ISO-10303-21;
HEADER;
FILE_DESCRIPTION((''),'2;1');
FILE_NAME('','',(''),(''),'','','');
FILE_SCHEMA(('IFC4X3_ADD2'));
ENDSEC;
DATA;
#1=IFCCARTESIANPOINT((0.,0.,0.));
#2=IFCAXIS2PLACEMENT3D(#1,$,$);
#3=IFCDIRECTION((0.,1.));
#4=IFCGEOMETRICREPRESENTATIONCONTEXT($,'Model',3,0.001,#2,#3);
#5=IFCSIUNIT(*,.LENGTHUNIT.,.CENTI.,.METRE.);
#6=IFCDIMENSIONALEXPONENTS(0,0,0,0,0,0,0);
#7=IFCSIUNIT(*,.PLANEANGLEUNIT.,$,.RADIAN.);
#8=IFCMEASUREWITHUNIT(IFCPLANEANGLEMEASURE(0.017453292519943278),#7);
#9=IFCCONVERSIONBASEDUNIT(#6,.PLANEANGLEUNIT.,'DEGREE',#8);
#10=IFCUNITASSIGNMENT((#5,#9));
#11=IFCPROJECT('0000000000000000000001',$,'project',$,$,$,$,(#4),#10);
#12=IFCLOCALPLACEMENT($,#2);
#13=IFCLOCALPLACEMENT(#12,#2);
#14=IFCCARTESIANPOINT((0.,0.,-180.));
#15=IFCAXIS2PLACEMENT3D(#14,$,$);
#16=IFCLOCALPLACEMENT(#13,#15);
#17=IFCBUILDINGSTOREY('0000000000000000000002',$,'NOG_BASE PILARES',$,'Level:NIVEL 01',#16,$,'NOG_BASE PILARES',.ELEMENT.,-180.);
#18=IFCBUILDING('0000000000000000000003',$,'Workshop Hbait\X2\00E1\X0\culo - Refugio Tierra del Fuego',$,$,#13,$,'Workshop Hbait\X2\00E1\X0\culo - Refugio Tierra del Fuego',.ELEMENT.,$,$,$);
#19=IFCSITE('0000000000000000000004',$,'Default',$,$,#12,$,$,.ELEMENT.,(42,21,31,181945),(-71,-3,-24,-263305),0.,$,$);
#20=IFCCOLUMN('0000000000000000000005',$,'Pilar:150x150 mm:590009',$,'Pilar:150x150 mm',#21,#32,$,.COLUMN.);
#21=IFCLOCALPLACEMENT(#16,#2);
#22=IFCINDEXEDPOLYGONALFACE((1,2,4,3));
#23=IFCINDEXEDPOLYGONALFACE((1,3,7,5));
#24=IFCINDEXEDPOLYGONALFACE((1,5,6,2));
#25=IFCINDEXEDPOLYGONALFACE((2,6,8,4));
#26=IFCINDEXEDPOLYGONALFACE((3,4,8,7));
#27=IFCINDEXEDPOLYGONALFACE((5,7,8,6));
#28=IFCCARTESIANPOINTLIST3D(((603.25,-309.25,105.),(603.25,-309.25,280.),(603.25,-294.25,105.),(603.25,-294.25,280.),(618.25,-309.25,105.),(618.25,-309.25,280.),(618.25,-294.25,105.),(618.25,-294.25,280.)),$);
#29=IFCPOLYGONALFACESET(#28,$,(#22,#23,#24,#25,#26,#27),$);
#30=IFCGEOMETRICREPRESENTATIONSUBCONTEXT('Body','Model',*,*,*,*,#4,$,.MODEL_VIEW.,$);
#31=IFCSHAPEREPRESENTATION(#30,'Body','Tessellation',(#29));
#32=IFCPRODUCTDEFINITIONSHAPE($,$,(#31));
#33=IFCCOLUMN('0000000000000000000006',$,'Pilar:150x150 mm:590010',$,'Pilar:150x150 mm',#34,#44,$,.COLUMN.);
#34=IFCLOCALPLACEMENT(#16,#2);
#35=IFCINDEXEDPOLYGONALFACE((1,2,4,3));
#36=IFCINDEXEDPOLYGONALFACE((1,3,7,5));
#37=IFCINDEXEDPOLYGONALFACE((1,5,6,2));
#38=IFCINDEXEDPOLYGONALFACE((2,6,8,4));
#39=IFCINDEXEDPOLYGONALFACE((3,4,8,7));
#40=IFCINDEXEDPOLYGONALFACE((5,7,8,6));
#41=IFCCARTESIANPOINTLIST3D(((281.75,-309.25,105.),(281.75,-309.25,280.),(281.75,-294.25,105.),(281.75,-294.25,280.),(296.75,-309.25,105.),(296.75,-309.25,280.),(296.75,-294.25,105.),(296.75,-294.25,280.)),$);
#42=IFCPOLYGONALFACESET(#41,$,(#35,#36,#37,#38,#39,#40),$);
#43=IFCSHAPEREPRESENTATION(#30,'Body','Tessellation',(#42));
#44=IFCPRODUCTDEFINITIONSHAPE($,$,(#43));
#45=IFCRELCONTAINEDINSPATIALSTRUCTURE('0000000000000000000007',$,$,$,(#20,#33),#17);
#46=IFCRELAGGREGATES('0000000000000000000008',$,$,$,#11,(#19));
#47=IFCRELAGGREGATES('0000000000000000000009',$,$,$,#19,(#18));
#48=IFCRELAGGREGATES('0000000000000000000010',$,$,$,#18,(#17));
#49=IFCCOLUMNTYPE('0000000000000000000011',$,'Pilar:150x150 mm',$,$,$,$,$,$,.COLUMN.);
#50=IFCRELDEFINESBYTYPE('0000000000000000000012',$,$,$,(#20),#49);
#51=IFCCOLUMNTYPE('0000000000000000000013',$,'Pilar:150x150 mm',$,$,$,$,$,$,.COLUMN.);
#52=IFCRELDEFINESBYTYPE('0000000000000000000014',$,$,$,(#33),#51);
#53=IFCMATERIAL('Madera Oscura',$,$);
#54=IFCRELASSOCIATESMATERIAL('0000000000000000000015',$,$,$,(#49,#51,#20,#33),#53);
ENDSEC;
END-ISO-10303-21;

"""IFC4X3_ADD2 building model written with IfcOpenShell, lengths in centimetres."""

from ifc_helpers import new_model, entity, si_unit, converted_unit, direction, frame, origin, origin_2d_with_axis, place, context, subcontext, project, spatial, rectangle, extrude, source, transform, mapped, material, material_profile, profile_set, profile_usage, type_object, type_shapes, element, save


model = new_model("IFC4X3_ADD2")

# Units and contexts
model_context = context("Model", 3, precision=0.001, world=origin(), true_north=direction((0.0, 1.0)))
body_context = subcontext(model_context, "Body", "Model", "MODEL_VIEW")
ifc_project = project(units=[si_unit("LENGTHUNIT", "METRE", prefix="CENTI"), converted_unit("PLANEANGLEUNIT", "DEGREE", entity("IfcPlaneAngleMeasure", 0.017453292519943278), si_unit("PLANEANGLEUNIT", "RADIAN"), dimensions=[0, 0, 0, 0, 0, 0, 0])], contexts=[model_context])

# Site, building, storey
site_placement = place(None, origin())
site = spatial("IfcSite", under=ifc_project, at=site_placement, Name="Default", CompositionType="ELEMENT", RefLatitude=(42, 21, 31, 181945), RefLongitude=(-71, -3, -24, -263305), RefElevation=0.0)
building_placement = place(site_placement, origin())
building = spatial("IfcBuilding", under=site, at=building_placement, Name="Workshop Hbaitáculo - Refugio Tierra del Fuego", LongName="Workshop Hbaitáculo - Refugio Tierra del Fuego", CompositionType="ELEMENT")
storey_placement = place(building_placement, frame((0.0, 0.0, -180.0)))
storey = spatial("IfcBuildingStorey", under=building, at=storey_placement, Name="NOG_BASE PILARES", ObjectType="Level:NIVEL 01", LongName="NOG_BASE PILARES", CompositionType="ELEMENT", Elevation=-180.0)

# Columns
ifc_material = material(Name="Madera Oscura")
ifc_material_profile = material_profile(ifc_material, rectangle(XDim=15.0, YDim=15.0, at=origin_2d_with_axis()), Name="150x150 mm")
ifc_profile_set = profile_set([ifc_material_profile], Name="150x150 mm")
ifc_profile_usage = profile_usage(ifc_profile_set)
column_type_1 = type_object("IfcColumnType", Name="Pilar:150x150 mm", PredefinedType="COLUMN", material=ifc_profile_set)
shared_shape_1 = source(origin(), body_context, "Body", "SweptSolid", [
    extrude(rectangle(XDim=15.0, YDim=15.0, at=origin_2d_with_axis()), frame((0.0, 0.0, -75.0), z_axis=(0.0, 0.0, 1.0), x_axis=(-1.0, 0.0, 0.0)), (0.0, 0.0, 1.0), 175.0),
])
type_shapes(column_type_1, [shared_shape_1])
column_1_placement = place(storey_placement, frame((610.75, -301.75, 180.0), z_axis=(0.0, 0.0, 1.0), x_axis=(-1.0, 0.0, 0.0)))
element("IfcColumn", 1, at=column_1_placement, inside=storey, type_object=column_type_1, material=ifc_profile_usage, Name="Pilar:150x150 mm:590009", ObjectType="Pilar:150x150 mm", PredefinedType="COLUMN", context=body_context, shape_type="MappedRepresentation", body=[
    mapped(shared_shape_1, transform((0.0, 0.0, 0.0), scale=1.0)),
])
column_type_2 = type_object("IfcColumnType", Name="Pilar:150x150 mm", PredefinedType="COLUMN", material=ifc_profile_set)
shared_shape_2 = source(origin(), body_context, "Body", "SweptSolid", [
    extrude(rectangle(XDim=15.0, YDim=15.0, at=origin_2d_with_axis()), frame((0.0, 0.0, -75.0), z_axis=(0.0, 0.0, 1.0), x_axis=(0.0, 1.0, 0.0)), (0.0, 0.0, 1.0), 175.0),
])
type_shapes(column_type_2, [shared_shape_2])
column_2_placement = place(storey_placement, frame((289.25, -301.75, 180.0)))
element("IfcColumn", 2, at=column_2_placement, inside=storey, type_object=column_type_2, material=ifc_profile_usage, Name="Pilar:150x150 mm:590010", ObjectType="Pilar:150x150 mm", PredefinedType="COLUMN", context=body_context, shape_type="MappedRepresentation", body=[
    mapped(shared_shape_2, transform((0.0, 0.0, 0.0), scale=1.0)),
])

save(model, "model.ifc")
